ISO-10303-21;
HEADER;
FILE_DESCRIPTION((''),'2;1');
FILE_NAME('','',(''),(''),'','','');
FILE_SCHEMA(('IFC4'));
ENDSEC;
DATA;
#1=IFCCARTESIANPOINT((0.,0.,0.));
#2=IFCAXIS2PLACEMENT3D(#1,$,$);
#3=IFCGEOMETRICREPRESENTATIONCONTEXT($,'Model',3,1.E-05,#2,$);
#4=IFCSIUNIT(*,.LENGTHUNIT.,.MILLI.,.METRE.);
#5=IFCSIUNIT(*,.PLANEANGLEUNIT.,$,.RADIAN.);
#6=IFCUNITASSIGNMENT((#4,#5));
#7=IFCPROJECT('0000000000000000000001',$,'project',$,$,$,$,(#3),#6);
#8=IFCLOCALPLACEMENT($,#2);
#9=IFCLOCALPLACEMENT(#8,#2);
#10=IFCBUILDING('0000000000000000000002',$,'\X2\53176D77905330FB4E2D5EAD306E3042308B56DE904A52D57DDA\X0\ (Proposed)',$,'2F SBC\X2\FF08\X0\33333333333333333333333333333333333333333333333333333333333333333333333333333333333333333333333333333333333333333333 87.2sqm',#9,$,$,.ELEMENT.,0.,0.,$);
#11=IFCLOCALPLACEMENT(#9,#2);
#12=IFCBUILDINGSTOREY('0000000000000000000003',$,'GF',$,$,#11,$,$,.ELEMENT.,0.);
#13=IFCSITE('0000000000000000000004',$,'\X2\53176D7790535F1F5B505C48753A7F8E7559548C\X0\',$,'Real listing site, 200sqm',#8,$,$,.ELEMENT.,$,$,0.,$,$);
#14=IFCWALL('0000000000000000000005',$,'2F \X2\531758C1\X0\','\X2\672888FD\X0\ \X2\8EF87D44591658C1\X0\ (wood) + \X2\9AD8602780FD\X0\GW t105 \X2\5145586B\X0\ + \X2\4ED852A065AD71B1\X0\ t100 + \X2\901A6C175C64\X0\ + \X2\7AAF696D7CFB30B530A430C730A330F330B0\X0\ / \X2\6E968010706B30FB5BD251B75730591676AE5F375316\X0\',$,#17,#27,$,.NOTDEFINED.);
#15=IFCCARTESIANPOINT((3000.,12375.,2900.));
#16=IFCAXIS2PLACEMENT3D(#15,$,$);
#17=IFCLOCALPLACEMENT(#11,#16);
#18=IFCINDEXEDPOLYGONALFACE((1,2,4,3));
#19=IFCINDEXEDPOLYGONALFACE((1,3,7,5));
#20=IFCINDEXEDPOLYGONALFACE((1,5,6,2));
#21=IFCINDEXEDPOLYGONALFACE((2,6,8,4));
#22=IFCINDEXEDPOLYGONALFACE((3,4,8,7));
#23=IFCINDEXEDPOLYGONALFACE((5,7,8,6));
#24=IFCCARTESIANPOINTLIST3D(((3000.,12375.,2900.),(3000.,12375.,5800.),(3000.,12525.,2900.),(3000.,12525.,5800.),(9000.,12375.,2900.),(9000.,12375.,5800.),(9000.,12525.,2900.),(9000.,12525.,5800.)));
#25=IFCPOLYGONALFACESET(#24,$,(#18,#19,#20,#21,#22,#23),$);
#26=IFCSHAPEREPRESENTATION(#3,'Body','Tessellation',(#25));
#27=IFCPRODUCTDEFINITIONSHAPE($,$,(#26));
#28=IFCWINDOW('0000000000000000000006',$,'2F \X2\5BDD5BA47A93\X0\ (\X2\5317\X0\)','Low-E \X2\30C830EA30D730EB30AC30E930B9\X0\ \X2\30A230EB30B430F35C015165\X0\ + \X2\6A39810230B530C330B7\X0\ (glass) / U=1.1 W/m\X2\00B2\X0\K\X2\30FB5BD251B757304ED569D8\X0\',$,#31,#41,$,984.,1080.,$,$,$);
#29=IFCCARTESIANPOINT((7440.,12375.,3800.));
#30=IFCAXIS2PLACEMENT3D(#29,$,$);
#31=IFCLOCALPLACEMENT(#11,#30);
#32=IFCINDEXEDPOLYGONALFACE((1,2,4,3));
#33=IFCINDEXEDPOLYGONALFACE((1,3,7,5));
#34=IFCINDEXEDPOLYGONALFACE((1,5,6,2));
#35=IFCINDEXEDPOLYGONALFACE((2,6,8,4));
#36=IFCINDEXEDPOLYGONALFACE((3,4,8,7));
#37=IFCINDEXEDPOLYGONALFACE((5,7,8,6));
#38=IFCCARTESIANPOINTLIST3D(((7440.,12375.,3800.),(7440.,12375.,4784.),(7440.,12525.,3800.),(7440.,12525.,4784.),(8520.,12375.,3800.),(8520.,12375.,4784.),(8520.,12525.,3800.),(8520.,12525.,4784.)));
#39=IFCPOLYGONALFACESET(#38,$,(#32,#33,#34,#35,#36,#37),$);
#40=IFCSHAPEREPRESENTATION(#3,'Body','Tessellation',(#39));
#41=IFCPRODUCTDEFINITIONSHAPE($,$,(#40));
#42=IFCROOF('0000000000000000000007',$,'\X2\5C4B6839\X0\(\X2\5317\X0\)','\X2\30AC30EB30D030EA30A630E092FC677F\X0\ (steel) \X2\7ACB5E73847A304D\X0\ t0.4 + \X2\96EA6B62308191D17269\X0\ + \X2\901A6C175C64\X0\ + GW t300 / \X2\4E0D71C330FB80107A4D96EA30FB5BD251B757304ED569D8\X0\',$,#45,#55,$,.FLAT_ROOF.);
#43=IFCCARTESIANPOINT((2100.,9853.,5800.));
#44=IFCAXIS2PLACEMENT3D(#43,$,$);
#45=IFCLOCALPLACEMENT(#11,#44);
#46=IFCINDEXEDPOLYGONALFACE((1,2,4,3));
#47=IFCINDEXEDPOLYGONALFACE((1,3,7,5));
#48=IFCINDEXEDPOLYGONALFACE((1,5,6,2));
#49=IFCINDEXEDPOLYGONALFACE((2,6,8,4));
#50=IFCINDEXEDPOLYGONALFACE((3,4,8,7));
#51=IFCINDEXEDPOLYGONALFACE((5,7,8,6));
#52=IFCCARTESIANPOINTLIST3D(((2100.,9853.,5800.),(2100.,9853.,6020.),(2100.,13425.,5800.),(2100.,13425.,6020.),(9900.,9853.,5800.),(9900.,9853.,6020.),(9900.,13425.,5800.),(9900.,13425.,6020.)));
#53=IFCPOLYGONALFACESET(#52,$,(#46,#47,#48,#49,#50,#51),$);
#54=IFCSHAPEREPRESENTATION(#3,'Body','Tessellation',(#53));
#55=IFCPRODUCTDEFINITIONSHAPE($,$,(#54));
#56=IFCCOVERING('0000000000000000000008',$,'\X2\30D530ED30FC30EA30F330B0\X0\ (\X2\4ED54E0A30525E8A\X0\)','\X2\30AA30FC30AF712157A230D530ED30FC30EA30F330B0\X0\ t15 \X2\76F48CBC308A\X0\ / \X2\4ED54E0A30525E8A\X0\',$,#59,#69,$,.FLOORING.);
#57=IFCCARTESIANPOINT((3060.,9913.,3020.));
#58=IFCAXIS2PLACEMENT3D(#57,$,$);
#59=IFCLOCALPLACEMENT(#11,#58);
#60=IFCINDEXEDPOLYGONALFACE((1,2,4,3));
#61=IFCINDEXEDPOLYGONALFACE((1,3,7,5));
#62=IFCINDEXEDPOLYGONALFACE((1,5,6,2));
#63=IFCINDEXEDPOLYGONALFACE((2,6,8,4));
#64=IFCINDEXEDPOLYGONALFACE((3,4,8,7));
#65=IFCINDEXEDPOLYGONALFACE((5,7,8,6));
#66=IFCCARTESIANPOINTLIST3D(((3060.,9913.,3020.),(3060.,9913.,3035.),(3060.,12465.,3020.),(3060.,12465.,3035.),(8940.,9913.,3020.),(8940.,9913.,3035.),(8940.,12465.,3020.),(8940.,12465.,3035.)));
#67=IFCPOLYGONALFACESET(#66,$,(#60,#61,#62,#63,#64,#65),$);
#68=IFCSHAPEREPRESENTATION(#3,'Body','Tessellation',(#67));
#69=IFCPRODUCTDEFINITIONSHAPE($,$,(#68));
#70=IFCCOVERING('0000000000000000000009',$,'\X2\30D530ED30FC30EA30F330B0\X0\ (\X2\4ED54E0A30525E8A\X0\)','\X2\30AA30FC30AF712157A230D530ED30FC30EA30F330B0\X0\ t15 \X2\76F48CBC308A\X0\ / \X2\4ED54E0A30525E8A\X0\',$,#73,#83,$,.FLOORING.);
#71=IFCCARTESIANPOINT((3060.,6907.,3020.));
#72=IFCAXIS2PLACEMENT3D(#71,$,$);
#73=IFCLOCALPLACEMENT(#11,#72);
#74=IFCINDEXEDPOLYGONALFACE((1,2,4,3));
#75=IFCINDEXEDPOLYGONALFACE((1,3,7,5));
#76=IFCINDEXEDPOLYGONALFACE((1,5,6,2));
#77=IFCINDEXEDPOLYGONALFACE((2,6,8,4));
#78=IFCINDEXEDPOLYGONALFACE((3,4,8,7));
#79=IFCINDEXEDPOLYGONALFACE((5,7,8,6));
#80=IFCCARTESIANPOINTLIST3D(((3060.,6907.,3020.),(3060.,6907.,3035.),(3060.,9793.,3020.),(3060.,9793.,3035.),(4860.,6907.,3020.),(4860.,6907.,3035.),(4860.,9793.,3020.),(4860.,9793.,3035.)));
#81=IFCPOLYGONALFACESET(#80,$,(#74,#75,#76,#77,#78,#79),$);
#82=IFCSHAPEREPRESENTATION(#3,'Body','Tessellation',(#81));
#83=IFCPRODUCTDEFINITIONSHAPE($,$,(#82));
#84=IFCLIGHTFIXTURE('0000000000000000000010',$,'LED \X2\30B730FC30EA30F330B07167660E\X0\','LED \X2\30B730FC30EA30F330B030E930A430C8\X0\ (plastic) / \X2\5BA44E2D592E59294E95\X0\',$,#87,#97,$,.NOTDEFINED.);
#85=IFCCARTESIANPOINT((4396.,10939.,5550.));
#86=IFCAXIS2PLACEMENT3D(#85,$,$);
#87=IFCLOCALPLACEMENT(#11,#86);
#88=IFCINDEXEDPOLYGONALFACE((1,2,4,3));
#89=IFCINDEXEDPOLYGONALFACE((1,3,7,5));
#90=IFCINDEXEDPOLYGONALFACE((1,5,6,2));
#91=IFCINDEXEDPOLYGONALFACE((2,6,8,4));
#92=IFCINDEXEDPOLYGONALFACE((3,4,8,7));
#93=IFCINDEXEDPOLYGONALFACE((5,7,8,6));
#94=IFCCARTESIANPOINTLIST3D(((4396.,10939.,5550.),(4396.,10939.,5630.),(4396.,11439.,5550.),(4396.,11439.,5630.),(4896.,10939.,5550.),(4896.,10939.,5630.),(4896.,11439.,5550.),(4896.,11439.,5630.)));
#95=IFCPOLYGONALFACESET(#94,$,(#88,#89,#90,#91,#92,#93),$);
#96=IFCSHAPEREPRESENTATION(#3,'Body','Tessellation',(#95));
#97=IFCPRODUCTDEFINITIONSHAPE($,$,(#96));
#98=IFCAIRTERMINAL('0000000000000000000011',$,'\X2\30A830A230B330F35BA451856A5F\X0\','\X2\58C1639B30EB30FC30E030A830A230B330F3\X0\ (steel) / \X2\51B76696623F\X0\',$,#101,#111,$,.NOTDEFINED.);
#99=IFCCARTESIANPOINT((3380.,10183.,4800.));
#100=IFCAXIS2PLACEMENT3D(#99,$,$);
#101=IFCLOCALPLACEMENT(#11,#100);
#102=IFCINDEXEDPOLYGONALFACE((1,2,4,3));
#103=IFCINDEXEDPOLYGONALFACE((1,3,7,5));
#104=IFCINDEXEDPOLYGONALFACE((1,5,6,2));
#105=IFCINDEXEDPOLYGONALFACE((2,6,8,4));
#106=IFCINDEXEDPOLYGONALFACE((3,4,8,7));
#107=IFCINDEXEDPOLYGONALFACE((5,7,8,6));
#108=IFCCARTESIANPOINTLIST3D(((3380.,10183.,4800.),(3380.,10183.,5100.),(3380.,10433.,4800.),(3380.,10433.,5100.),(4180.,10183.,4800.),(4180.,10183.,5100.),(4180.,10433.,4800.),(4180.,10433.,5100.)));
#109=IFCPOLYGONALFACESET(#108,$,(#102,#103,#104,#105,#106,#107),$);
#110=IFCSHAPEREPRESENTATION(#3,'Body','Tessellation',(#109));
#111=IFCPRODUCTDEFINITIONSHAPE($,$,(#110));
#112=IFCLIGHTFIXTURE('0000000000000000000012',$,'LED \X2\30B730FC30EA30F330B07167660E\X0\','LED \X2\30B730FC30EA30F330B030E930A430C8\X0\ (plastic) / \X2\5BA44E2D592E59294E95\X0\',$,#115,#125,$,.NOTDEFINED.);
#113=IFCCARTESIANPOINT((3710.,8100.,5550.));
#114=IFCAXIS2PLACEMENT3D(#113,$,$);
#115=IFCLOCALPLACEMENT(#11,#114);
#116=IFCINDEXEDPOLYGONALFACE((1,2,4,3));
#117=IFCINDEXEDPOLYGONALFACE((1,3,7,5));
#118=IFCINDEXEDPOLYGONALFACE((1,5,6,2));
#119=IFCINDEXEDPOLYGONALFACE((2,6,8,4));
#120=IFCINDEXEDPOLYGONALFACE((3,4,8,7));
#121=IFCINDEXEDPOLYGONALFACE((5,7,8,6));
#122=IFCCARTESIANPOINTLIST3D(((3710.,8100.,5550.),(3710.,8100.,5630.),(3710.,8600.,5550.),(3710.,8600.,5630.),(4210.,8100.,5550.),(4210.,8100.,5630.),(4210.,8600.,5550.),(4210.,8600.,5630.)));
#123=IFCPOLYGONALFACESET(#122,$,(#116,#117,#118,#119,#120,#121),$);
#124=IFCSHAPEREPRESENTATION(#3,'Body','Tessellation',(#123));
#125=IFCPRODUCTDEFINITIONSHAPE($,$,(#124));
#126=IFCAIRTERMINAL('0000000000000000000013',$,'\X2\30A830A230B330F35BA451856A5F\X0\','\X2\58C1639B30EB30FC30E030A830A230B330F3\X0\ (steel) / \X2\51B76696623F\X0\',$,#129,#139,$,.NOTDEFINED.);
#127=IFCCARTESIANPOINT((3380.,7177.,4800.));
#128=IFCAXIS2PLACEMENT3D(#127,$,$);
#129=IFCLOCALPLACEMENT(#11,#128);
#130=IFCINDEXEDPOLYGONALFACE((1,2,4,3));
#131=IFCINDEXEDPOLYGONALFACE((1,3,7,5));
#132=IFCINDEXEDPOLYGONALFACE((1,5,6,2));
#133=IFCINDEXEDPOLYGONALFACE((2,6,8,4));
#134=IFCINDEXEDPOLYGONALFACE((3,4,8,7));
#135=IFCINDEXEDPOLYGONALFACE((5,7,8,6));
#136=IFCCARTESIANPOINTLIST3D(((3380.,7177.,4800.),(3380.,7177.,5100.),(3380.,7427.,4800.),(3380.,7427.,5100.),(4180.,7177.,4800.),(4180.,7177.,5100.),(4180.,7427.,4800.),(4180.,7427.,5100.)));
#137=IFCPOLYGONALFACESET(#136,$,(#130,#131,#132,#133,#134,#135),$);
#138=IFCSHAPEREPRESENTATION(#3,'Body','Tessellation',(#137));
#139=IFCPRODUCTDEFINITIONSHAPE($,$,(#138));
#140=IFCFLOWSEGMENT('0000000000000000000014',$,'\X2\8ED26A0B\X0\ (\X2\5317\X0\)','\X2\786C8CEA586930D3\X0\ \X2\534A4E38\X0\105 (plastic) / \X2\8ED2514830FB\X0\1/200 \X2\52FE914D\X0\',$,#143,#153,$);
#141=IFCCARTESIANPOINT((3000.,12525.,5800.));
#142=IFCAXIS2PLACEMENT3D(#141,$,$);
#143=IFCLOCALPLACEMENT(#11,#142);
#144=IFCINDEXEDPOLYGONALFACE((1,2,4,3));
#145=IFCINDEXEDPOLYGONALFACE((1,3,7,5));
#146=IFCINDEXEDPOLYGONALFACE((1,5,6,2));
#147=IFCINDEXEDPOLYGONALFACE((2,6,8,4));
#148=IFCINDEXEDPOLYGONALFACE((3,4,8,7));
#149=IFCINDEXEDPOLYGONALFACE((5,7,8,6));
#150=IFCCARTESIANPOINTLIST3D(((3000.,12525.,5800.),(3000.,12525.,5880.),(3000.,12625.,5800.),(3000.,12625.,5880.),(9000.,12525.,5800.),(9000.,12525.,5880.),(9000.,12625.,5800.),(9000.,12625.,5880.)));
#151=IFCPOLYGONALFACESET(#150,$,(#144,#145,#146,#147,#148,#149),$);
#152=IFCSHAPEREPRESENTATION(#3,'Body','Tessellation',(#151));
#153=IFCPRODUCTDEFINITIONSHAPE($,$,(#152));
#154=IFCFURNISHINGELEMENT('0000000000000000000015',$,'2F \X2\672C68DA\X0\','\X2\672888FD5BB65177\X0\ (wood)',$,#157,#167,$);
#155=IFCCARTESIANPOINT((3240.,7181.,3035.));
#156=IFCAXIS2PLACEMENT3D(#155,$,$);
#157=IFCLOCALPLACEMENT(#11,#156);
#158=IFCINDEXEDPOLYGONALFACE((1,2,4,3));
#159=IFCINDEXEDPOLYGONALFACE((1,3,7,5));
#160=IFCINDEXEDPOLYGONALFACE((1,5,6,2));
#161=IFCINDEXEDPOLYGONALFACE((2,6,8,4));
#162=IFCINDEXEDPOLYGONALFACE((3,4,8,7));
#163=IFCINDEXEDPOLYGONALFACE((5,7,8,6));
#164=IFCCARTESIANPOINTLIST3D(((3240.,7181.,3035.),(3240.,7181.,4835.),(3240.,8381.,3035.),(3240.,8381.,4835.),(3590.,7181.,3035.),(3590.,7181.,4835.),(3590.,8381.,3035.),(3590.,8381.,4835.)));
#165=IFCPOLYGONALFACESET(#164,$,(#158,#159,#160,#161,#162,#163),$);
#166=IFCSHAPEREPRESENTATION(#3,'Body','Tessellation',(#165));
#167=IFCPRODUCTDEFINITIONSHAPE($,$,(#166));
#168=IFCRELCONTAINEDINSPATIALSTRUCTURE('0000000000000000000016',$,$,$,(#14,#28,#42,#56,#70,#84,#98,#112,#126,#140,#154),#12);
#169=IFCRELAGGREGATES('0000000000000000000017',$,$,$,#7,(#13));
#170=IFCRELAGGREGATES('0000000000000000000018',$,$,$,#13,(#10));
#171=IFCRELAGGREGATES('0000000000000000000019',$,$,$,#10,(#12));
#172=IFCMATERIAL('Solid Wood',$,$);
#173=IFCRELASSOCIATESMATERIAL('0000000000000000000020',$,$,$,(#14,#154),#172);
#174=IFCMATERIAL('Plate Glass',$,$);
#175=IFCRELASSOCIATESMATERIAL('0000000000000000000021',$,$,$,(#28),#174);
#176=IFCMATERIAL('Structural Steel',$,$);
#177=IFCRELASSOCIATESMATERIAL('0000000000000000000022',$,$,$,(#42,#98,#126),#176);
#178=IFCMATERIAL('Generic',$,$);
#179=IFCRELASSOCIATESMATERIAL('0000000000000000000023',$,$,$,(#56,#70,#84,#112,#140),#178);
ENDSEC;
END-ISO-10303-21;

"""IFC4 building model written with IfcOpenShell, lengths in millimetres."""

from ifc_helpers import new_model, si_unit, frame, frame_2d, origin, place, context, project, spatial, rectangle, extrude, material, element, fill, save


model = new_model("IFC4")

# Units and contexts
model_context = context("Model", 3, precision=1e-05, world=origin())
ifc_project = project(units=[si_unit("LENGTHUNIT", "METRE", prefix="MILLI"), si_unit("PLANEANGLEUNIT", "RADIAN")], contexts=[model_context])

# Site, building, storey
site_placement = place(None, origin())
site = spatial("IfcSite", under=ifc_project, at=site_placement, Name="北海道弟子屈町美留和", ObjectType="Real listing site, 200sqm", CompositionType="ELEMENT", RefElevation=0.0)
building_placement = place(site_placement, origin())
building = spatial("IfcBuilding", under=site, at=building_placement, Name="北海道・中庭のある回遊動線 (Proposed)", ObjectType="2F SBC（33333333333333333333333333333333333333333333333333333333333333333333333333333333333333333333333333333333333333333333 87.2sqm", CompositionType="ELEMENT", ElevationOfRefHeight=0.0, ElevationOfTerrain=0.0)
storey_placement = place(building_placement, origin())
storey = spatial("IfcBuildingStorey", under=building, at=storey_placement, Name="GF", CompositionType="ELEMENT", Elevation=0.0)

# Shared definitions
ifc_material_1 = material(Name="Solid Wood")

# Wall, opening, window
wall_placement = place(storey_placement, frame((3000.0, 12375.0, 2900.0)))
wall = element("IfcWall", 1, at=wall_placement, inside=storey, material=ifc_material_1, Name="2F 北壁", Description="木製 軸組外壁 (wood) + 高性能GW t105 充填 + 付加断熱 t100 + 通気層 + 窯業系サイディング / 準耐火・寒冷地外皮強化", PredefinedType="NOTDEFINED", context=model_context, shape_type="SweptSolid", body=[
    extrude(rectangle(XDim=6000.0, YDim=150.0, at=frame_2d((3000.0, 75.0))), frame((3000.0, 12375.0, 2900.0)), (0.0, 0.0, 1.0), 2900.0),
])
opening_placement = place(storey_placement, frame((7440.0, 12375.0, 3800.0)))
opening = element("IfcOpeningElement", 2, at=opening_placement, cuts=wall, PredefinedType="NOTDEFINED", context=model_context, shape_type="SweptSolid", body=[
    extrude(rectangle(XDim=1080.0, YDim=150.0, at=frame_2d((540.0, 75.0))), frame((7440.0, 12375.0, 3800.0)), (0.0, 0.0, 1.0), 984.0),
])
ifc_material_2 = material(Name="Plate Glass")
window_placement = place(storey_placement, frame((7440.0, 12375.0, 3800.0)))
window = element("IfcWindow", 3, at=window_placement, inside=storey, material=ifc_material_2, Name="2F 寝室窓 (北)", Description="Low-E トリプルガラス アルゴン封入 + 樹脂サッシ (glass) / U=1.1 W/m²K・寒冷地仕様", OverallHeight=984.0, OverallWidth=1080.0, context=model_context, shape_type="SweptSolid", body=[
    extrude(rectangle(XDim=1080.0, YDim=150.0, at=frame_2d((540.0, 75.0))), frame((7440.0, 12375.0, 3800.0)), (0.0, 0.0, 1.0), 984.0),
])
fill(opening, window)

# Roof
ifc_material_3 = material(Name="Structural Steel")
for number, where, name in (
    (4, (2100.0, 9853.0, 5800.0), "屋根(北)"),
):
    element("IfcRoof", number, at=place(storey_placement, frame(where)), inside=storey, material=ifc_material_3, Name=name, Description="ガルバリウム鋼板 (steel) 立平葺き t0.4 + 雪止め金物 + 通気層 + GW t300 / 不燃・耐積雪・寒冷地仕様", PredefinedType="FLAT_ROOF", context=model_context, shape_type="SweptSolid", body=[
        extrude(rectangle(XDim=7800.0, YDim=3572.0, at=frame_2d((3900.0, 1786.0))), frame((2100.0, 9853.0, 5800.0)), (0.0, 0.0, 1.0), 220.0),
    ])

# Coverings
ifc_material_4 = material(Name="Generic")
covering_1_placement = place(storey_placement, frame((3060.0, 9913.0, 3020.0)))
element("IfcCovering", 5, at=covering_1_placement, inside=storey, material=ifc_material_4, Name="フローリング (仕上げ床)", Description="オーク無垢フローリング t15 直貼り / 仕上げ床", PredefinedType="FLOORING", context=model_context, shape_type="SweptSolid", body=[
    extrude(rectangle(XDim=5880.0, YDim=2552.0, at=frame_2d((2940.0, 1276.0))), frame((3060.0, 9913.0, 3020.0)), (0.0, 0.0, 1.0), 15.0),
])
covering_2_placement = place(storey_placement, frame((3060.0, 6907.0, 3020.0)))
element("IfcCovering", 6, at=covering_2_placement, inside=storey, material=ifc_material_4, Name="フローリング (仕上げ床)", Description="オーク無垢フローリング t15 直貼り / 仕上げ床", PredefinedType="FLOORING", context=model_context, shape_type="SweptSolid", body=[
    extrude(rectangle(XDim=1800.0, YDim=2886.0, at=frame_2d((900.0, 1443.0))), frame((3060.0, 6907.0, 3020.0)), (0.0, 0.0, 1.0), 15.0),
])

# Light fixture
light_fixture_1_placement = place(storey_placement, frame((4396.0, 10939.0, 5550.0)))
element("IfcLightFixture", 7, at=light_fixture_1_placement, inside=storey, material=ifc_material_4, Name="LED シーリング照明", Description="LED シーリングライト (plastic) / 室中央天井", PredefinedType="NOTDEFINED", context=model_context, shape_type="SweptSolid", body=[
    extrude(rectangle(XDim=500.0, YDim=500.0, at=frame_2d((250.0, 250.0))), frame((4396.0, 10939.0, 5550.0)), (0.0, 0.0, 1.0), 80.0),
])

# Air terminal
air_terminal_1_placement = place(storey_placement, frame((3380.0, 10183.0, 4800.0)))
element("IfcAirTerminal", 8, at=air_terminal_1_placement, inside=storey, material=ifc_material_3, Name="エアコン室内機", Description="壁掛ルームエアコン (steel) / 冷暖房", PredefinedType="NOTDEFINED", context=model_context, shape_type="SweptSolid", body=[
    extrude(rectangle(XDim=800.0, YDim=250.0, at=frame_2d((400.0, 125.0))), frame((3380.0, 10183.0, 4800.0)), (0.0, 0.0, 1.0), 300.0),
])

# Light fixture
light_fixture_2_placement = place(storey_placement, frame((3710.0, 8100.0, 5550.0)))
element("IfcLightFixture", 9, at=light_fixture_2_placement, inside=storey, material=ifc_material_4, Name="LED シーリング照明", Description="LED シーリングライト (plastic) / 室中央天井", PredefinedType="NOTDEFINED", context=model_context, shape_type="SweptSolid", body=[
    extrude(rectangle(XDim=500.0, YDim=500.0, at=frame_2d((250.0, 250.0))), frame((3710.0, 8100.0, 5550.0)), (0.0, 0.0, 1.0), 80.0),
])

# Air terminal
air_terminal_2_placement = place(storey_placement, frame((3380.0, 7177.0, 4800.0)))
element("IfcAirTerminal", 10, at=air_terminal_2_placement, inside=storey, material=ifc_material_3, Name="エアコン室内機", Description="壁掛ルームエアコン (steel) / 冷暖房", PredefinedType="NOTDEFINED", context=model_context, shape_type="SweptSolid", body=[
    extrude(rectangle(XDim=800.0, YDim=250.0, at=frame_2d((400.0, 125.0))), frame((3380.0, 7177.0, 4800.0)), (0.0, 0.0, 1.0), 300.0),
])

# Flow segment
flow_segment_placement = place(storey_placement, frame((3000.0, 12525.0, 5800.0)))
element("IfcFlowSegment", 11, at=flow_segment_placement, inside=storey, material=ifc_material_4, Name="軒樋 (北)", Description="硬質塩ビ 半丸105 (plastic) / 軒先・1/200 勾配", context=model_context, shape_type="SweptSolid", body=[
    extrude(rectangle(XDim=6000.0, YDim=100.0, at=frame_2d((3000.0, 50.0))), frame((3000.0, 12525.0, 5800.0)), (0.0, 0.0, 1.0), 80.0),
])

# Furnishing element
furnishing_placement = place(storey_placement, frame((3240.0, 7181.0, 3035.0)))
element("IfcFurnishingElement", 12, at=furnishing_placement, inside=storey, material=ifc_material_1, Name="2F 本棚", Description="木製家具 (wood)", context=model_context, shape_type="SweptSolid", body=[
    extrude(rectangle(XDim=350.0, YDim=1200.0, at=frame_2d((175.0, 600.0))), frame((3240.0, 7181.0, 3035.0)), (0.0, 0.0, 1.0), 1800.0),
])

save(model, "model.ifc")
